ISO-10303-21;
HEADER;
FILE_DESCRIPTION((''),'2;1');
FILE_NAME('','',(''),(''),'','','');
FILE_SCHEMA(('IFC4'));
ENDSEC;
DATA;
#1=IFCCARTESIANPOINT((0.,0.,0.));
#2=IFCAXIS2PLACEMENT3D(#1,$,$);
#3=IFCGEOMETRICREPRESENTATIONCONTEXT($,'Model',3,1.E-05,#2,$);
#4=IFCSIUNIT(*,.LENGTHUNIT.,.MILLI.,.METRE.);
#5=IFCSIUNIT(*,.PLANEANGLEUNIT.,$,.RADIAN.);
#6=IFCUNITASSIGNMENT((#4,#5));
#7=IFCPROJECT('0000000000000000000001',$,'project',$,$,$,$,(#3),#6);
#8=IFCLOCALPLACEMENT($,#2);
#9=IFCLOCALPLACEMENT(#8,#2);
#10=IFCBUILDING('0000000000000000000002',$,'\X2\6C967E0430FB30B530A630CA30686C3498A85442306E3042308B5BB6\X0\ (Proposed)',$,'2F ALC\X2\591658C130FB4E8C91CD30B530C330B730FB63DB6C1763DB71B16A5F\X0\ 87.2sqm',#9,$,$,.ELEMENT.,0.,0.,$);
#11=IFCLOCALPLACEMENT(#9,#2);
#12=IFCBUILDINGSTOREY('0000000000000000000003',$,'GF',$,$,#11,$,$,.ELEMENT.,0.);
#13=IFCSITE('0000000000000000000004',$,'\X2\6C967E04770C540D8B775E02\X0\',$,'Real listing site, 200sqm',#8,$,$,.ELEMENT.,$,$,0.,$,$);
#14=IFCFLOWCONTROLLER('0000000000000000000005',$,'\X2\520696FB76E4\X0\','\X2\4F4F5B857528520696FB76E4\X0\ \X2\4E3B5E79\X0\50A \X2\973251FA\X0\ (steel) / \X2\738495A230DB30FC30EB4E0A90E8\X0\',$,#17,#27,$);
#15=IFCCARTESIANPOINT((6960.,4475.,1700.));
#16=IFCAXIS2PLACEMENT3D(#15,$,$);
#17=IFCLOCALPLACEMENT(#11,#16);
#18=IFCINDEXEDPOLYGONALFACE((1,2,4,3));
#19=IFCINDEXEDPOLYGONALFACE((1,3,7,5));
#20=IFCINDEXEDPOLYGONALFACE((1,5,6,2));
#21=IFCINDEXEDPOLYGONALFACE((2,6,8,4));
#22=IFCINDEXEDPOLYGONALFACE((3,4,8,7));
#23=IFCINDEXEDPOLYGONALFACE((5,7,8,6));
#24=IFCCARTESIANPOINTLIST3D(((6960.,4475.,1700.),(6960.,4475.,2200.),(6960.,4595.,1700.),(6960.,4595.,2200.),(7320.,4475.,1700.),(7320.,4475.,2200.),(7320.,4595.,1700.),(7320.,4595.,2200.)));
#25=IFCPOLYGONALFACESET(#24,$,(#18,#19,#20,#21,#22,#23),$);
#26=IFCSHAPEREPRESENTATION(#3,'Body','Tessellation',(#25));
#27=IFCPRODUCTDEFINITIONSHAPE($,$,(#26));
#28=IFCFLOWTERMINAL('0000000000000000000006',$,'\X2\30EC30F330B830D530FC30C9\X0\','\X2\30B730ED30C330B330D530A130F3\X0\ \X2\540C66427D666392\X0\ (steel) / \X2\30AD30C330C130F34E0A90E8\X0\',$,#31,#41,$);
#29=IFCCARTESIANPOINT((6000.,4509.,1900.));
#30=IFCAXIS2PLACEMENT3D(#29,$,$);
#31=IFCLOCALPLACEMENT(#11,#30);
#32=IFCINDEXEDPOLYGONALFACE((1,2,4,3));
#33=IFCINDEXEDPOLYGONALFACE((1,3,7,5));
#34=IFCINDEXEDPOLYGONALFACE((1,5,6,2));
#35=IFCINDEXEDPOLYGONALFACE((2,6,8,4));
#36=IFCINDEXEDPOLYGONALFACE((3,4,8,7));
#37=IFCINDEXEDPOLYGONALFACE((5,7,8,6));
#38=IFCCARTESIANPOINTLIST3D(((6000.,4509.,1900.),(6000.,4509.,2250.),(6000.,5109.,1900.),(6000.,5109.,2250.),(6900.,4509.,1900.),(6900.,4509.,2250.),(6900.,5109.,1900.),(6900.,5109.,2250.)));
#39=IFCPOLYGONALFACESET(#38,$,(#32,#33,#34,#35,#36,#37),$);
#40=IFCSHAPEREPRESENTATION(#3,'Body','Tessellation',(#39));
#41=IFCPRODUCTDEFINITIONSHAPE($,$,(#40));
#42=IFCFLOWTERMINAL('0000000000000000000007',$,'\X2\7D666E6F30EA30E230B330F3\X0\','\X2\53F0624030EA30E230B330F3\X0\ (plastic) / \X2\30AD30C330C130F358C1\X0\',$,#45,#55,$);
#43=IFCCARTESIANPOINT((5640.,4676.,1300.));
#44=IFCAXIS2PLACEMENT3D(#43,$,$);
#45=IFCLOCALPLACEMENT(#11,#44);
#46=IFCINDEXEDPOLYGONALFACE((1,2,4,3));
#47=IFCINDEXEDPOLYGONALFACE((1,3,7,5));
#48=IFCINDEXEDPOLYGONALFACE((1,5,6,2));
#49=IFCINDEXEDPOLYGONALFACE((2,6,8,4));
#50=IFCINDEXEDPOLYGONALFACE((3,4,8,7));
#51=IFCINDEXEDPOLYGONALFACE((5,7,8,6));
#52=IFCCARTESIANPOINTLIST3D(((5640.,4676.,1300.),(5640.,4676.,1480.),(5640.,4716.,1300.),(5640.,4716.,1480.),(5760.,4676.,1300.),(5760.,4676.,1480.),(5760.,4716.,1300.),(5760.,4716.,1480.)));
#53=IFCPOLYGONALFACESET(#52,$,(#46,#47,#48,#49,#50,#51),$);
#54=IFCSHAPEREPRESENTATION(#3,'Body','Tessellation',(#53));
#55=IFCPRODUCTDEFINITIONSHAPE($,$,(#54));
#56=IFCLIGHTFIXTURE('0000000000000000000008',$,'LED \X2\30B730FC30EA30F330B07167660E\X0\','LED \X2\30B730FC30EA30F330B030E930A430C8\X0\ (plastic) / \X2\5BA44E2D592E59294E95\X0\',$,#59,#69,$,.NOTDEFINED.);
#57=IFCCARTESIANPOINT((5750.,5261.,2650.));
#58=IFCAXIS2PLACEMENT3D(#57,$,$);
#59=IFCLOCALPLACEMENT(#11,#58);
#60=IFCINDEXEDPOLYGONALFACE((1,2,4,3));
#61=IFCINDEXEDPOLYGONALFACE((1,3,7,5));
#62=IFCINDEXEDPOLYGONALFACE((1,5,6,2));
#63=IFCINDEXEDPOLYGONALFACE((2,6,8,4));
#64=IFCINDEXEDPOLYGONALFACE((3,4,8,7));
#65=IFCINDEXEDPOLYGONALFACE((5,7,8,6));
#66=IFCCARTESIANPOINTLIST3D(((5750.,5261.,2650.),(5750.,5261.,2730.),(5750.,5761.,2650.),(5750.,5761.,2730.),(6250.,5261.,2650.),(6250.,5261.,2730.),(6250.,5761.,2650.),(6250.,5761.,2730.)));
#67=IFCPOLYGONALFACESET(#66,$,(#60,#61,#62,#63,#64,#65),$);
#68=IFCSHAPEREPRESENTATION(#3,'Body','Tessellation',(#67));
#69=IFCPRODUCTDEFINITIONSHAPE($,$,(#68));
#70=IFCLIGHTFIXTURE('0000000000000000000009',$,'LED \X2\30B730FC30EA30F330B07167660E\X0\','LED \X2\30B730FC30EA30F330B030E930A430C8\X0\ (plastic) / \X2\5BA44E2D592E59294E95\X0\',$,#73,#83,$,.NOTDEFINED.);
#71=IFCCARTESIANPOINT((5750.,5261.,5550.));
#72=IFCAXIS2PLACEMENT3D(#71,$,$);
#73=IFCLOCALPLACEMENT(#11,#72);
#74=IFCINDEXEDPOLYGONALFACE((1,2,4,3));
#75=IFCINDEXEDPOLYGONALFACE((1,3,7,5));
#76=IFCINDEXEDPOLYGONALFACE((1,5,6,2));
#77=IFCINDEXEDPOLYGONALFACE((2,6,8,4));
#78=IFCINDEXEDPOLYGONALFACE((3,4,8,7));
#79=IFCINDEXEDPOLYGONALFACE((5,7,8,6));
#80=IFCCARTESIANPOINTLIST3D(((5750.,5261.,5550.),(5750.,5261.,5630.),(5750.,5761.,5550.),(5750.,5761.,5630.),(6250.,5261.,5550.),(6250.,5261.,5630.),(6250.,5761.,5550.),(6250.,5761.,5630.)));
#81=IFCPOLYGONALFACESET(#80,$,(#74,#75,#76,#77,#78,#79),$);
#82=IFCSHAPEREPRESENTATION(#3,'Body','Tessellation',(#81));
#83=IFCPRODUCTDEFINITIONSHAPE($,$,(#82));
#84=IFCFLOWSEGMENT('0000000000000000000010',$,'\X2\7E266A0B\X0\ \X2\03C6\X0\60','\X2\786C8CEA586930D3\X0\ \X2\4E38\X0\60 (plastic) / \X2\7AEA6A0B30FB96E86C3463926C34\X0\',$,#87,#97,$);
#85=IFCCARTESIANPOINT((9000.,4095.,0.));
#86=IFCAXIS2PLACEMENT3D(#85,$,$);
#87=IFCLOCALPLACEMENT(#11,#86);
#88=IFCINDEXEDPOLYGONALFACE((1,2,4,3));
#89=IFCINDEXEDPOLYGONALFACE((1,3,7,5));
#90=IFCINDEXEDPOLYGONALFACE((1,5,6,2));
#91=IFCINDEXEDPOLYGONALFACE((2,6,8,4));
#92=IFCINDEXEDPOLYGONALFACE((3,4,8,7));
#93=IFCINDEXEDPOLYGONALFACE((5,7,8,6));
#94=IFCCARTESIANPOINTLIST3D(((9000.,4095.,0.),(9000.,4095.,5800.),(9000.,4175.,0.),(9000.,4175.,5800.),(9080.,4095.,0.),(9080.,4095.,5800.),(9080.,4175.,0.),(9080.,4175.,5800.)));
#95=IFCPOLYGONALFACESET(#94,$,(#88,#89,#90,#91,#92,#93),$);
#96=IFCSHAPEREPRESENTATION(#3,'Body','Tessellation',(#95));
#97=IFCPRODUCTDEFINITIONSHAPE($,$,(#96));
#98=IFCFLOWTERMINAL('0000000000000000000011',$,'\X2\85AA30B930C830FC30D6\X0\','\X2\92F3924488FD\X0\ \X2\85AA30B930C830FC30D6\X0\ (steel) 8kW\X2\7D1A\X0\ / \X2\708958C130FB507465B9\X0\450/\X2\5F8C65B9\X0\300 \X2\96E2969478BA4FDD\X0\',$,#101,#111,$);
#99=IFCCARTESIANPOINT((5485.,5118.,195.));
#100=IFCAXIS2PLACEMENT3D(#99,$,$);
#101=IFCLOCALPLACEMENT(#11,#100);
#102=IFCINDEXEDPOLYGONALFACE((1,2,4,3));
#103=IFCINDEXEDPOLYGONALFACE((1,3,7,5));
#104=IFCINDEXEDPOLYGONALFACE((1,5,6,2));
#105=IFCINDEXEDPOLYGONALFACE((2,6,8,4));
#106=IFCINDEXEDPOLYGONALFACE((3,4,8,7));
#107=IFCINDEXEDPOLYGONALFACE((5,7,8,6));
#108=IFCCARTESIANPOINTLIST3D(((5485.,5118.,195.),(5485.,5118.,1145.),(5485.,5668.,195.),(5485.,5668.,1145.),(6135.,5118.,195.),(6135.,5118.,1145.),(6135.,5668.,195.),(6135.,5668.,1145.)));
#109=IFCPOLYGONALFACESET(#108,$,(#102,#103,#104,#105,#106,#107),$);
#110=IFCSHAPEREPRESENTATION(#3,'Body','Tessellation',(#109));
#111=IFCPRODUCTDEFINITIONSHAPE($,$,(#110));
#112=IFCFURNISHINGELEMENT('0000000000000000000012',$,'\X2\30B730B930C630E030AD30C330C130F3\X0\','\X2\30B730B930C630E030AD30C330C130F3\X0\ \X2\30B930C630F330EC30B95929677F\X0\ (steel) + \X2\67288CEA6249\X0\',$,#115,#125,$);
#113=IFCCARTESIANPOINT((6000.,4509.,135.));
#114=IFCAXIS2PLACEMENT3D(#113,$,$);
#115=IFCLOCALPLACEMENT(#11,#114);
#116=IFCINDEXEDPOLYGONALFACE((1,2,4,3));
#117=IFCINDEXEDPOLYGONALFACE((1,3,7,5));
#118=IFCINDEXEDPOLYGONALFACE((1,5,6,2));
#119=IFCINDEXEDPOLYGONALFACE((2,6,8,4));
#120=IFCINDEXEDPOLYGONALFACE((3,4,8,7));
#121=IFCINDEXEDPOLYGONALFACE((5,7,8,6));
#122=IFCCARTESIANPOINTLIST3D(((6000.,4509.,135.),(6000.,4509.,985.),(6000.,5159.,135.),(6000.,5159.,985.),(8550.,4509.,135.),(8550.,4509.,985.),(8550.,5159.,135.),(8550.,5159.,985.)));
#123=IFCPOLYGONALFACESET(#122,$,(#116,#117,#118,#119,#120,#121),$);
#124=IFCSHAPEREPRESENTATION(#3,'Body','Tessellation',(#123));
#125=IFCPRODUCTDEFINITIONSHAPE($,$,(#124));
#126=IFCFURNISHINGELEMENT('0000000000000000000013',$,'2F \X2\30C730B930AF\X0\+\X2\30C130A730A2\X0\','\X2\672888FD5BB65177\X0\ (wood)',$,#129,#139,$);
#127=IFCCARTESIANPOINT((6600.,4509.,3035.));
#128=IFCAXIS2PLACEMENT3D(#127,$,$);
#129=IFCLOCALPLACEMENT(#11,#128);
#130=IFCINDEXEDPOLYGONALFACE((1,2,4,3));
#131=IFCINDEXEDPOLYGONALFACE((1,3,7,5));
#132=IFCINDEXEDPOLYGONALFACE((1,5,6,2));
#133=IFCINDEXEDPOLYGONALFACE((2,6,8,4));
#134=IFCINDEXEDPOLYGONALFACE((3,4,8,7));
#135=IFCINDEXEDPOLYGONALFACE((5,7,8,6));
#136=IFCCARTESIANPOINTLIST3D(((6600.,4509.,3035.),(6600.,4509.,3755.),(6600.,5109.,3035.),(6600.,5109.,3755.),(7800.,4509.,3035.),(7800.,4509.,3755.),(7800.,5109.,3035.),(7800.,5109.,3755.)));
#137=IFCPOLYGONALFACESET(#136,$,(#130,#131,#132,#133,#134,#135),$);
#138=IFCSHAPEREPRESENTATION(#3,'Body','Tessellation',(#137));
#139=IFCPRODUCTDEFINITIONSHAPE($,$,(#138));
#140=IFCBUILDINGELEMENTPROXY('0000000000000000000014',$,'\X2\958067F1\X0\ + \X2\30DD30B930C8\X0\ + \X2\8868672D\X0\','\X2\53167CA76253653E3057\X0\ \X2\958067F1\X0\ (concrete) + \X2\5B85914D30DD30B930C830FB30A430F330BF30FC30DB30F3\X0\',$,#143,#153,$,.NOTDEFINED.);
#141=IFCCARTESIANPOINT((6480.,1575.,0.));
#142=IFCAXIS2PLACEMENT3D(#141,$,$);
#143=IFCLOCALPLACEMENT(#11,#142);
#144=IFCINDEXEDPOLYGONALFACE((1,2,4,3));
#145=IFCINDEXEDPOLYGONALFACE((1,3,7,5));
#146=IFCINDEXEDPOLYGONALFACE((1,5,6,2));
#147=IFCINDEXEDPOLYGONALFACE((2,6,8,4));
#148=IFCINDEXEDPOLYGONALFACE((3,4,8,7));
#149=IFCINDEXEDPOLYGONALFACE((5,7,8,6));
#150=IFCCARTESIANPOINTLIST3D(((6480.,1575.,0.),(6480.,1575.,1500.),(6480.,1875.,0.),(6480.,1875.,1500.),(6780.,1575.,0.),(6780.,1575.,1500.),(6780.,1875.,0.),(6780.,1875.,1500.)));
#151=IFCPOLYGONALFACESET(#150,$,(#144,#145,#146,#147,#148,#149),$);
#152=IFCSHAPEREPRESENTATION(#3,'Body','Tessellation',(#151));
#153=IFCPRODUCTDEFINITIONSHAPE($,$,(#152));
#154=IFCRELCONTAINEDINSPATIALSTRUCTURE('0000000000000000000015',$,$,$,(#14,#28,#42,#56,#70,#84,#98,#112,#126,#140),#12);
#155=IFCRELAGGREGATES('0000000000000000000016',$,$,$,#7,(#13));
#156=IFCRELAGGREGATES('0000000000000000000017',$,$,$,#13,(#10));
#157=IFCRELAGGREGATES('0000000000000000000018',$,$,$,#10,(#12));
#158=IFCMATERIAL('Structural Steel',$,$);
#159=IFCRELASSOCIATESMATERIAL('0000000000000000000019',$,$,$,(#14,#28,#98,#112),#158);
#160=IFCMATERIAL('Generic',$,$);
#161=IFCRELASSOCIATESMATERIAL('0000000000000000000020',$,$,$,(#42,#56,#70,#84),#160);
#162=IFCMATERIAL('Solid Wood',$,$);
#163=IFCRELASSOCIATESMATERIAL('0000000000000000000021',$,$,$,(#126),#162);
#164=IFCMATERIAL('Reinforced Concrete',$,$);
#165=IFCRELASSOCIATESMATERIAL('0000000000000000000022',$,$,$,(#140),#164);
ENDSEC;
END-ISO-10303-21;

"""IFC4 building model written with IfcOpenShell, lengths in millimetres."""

from ifc_helpers import new_model, si_unit, frame, frame_2d, origin, place, context, project, spatial, rectangle, extrude, material, element, save


model = new_model("IFC4")

# Units and contexts
model_context = context("Model", 3, precision=1e-05, world=origin())
ifc_project = project(units=[si_unit("LENGTHUNIT", "METRE", prefix="MILLI"), si_unit("PLANEANGLEUNIT", "RADIAN")], contexts=[model_context])

# Site, building, storey
site_placement = place(None, origin())
site = spatial("IfcSite", under=ifc_project, at=site_placement, Name="沖縄県名護市", ObjectType="Real listing site, 200sqm", CompositionType="ELEMENT", RefElevation=0.0)
building_placement = place(site_placement, origin())
building = spatial("IfcBuilding", under=site, at=building_placement, Name="沖縄・サウナと水風呂のある家 (Proposed)", ObjectType="2F ALC外壁・二重サッシ・換気換熱機 87.2sqm", CompositionType="ELEMENT", ElevationOfRefHeight=0.0, ElevationOfTerrain=0.0)
storey_placement = place(building_placement, origin())
storey = spatial("IfcBuildingStorey", under=building, at=storey_placement, Name="GF", CompositionType="ELEMENT", Elevation=0.0)

# Shared definitions
ifc_material_1 = material(Name="Solid Wood")

# Shared definitions
ifc_material_2 = material(Name="Structural Steel")

# Shared definitions
ifc_material_3 = material(Name="Reinforced Concrete")

# Flow controller
flow_controller_placement = place(storey_placement, frame((6960.0, 4475.0, 1700.0)))
element("IfcFlowController", 1, at=flow_controller_placement, inside=storey, material=ifc_material_2, Name="分電盤", Description="住宅用分電盤 主幹50A 露出 (steel) / 玄関ホール上部", context=model_context, shape_type="SweptSolid", body=[
    extrude(rectangle(XDim=360.0, YDim=120.0, at=frame_2d((180.0, 60.0))), frame((6960.0, 4475.0, 1700.0)), (0.0, 0.0, 1.0), 500.0),
])

# Flow terminals
flow_terminal_1_placement = place(storey_placement, frame((6000.0, 4509.0, 1900.0)))
element("IfcFlowTerminal", 2, at=flow_terminal_1_placement, inside=storey, material=ifc_material_2, Name="レンジフード", Description="シロッコファン 同時給排 (steel) / キッチン上部", context=model_context, shape_type="SweptSolid", body=[
    extrude(rectangle(XDim=900.0, YDim=600.0, at=frame_2d((450.0, 300.0))), frame((6000.0, 4509.0, 1900.0)), (0.0, 0.0, 1.0), 350.0),
])
ifc_material_4 = material(Name="Generic")
flow_terminal_2_placement = place(storey_placement, frame((5640.0, 4676.0, 1300.0)))
element("IfcFlowTerminal", 3, at=flow_terminal_2_placement, inside=storey, material=ifc_material_4, Name="給湯リモコン", Description="台所リモコン (plastic) / キッチン壁", context=model_context, shape_type="SweptSolid", body=[
    extrude(rectangle(XDim=120.0, YDim=40.0, at=frame_2d((60.0, 20.0))), frame((5640.0, 4676.0, 1300.0)), (0.0, 0.0, 1.0), 180.0),
])

# Light fixtures
light_fixture_1_placement = place(storey_placement, frame((5750.0, 5261.0, 2650.0)))
element("IfcLightFixture", 4, at=light_fixture_1_placement, inside=storey, material=ifc_material_4, Name="LED シーリング照明", Description="LED シーリングライト (plastic) / 室中央天井", PredefinedType="NOTDEFINED", context=model_context, shape_type="SweptSolid", body=[
    extrude(rectangle(XDim=500.0, YDim=500.0, at=frame_2d((250.0, 250.0))), frame((5750.0, 5261.0, 2650.0)), (0.0, 0.0, 1.0), 80.0),
])
light_fixture_2_placement = place(storey_placement, frame((5750.0, 5261.0, 5550.0)))
element("IfcLightFixture", 5, at=light_fixture_2_placement, inside=storey, material=ifc_material_4, Name="LED シーリング照明", Description="LED シーリングライト (plastic) / 室中央天井", PredefinedType="NOTDEFINED", context=model_context, shape_type="SweptSolid", body=[
    extrude(rectangle(XDim=500.0, YDim=500.0, at=frame_2d((250.0, 250.0))), frame((5750.0, 5261.0, 5550.0)), (0.0, 0.0, 1.0), 80.0),
])

# Flow segment
flow_segment_placement = place(storey_placement, frame((9000.0, 4095.0, 0.0)))
element("IfcFlowSegment", 6, at=flow_segment_placement, inside=storey, material=ifc_material_4, Name="縦樋 φ60", Description="硬質塩ビ 丸60 (plastic) / 竪樋・雨水排水", context=model_context, shape_type="SweptSolid", body=[
    extrude(rectangle(XDim=80.0, YDim=80.0, at=frame_2d((40.0, 40.0))), frame((9000.0, 4095.0, 0.0)), (0.0, 0.0, 1.0), 5800.0),
])

# Flow terminal
flow_terminal_3_placement = place(storey_placement, frame((5485.0, 5118.0, 195.0)))
element("IfcFlowTerminal", 7, at=flow_terminal_3_placement, inside=storey, material=ifc_material_2, Name="薪ストーブ", Description="鋳鉄製 薪ストーブ (steel) 8kW級 / 炉壁・側方450/後方300 離隔確保", context=model_context, shape_type="SweptSolid", body=[
    extrude(rectangle(XDim=650.0, YDim=550.0, at=frame_2d((325.0, 275.0))), frame((5485.0, 5118.0, 195.0)), (0.0, 0.0, 1.0), 950.0),
])

# Furnishing elements
furnishing_1_placement = place(storey_placement, frame((6000.0, 4509.0, 135.0)))
element("IfcFurnishingElement", 8, at=furnishing_1_placement, inside=storey, material=ifc_material_2, Name="システムキッチン", Description="システムキッチン ステンレス天板 (steel) + 木質扉", context=model_context, shape_type="SweptSolid", body=[
    extrude(rectangle(XDim=2550.0, YDim=650.0, at=frame_2d((1275.0, 325.0))), frame((6000.0, 4509.0, 135.0)), (0.0, 0.0, 1.0), 850.0),
])
furnishing_2_placement = place(storey_placement, frame((6600.0, 4509.0, 3035.0)))
element("IfcFurnishingElement", 9, at=furnishing_2_placement, inside=storey, material=ifc_material_1, Name="2F デスク+チェア", Description="木製家具 (wood)", context=model_context, shape_type="SweptSolid", body=[
    extrude(rectangle(XDim=1200.0, YDim=600.0, at=frame_2d((600.0, 300.0))), frame((6600.0, 4509.0, 3035.0)), (0.0, 0.0, 1.0), 720.0),
])

# Building element proxy
proxy_placement = place(storey_placement, frame((6480.0, 1575.0, 0.0)))
element("IfcBuildingElementProxy", 10, at=proxy_placement, inside=storey, material=ifc_material_3, Name="門柱 + ポスト + 表札", Description="化粧打放し 門柱 (concrete) + 宅配ポスト・インターホン", PredefinedType="NOTDEFINED", context=model_context, shape_type="SweptSolid", body=[
    extrude(rectangle(XDim=300.0, YDim=300.0, at=frame_2d((150.0, 150.0))), frame((6480.0, 1575.0, 0.0)), (0.0, 0.0, 1.0), 1500.0),
])

save(model, "model.ifc")
